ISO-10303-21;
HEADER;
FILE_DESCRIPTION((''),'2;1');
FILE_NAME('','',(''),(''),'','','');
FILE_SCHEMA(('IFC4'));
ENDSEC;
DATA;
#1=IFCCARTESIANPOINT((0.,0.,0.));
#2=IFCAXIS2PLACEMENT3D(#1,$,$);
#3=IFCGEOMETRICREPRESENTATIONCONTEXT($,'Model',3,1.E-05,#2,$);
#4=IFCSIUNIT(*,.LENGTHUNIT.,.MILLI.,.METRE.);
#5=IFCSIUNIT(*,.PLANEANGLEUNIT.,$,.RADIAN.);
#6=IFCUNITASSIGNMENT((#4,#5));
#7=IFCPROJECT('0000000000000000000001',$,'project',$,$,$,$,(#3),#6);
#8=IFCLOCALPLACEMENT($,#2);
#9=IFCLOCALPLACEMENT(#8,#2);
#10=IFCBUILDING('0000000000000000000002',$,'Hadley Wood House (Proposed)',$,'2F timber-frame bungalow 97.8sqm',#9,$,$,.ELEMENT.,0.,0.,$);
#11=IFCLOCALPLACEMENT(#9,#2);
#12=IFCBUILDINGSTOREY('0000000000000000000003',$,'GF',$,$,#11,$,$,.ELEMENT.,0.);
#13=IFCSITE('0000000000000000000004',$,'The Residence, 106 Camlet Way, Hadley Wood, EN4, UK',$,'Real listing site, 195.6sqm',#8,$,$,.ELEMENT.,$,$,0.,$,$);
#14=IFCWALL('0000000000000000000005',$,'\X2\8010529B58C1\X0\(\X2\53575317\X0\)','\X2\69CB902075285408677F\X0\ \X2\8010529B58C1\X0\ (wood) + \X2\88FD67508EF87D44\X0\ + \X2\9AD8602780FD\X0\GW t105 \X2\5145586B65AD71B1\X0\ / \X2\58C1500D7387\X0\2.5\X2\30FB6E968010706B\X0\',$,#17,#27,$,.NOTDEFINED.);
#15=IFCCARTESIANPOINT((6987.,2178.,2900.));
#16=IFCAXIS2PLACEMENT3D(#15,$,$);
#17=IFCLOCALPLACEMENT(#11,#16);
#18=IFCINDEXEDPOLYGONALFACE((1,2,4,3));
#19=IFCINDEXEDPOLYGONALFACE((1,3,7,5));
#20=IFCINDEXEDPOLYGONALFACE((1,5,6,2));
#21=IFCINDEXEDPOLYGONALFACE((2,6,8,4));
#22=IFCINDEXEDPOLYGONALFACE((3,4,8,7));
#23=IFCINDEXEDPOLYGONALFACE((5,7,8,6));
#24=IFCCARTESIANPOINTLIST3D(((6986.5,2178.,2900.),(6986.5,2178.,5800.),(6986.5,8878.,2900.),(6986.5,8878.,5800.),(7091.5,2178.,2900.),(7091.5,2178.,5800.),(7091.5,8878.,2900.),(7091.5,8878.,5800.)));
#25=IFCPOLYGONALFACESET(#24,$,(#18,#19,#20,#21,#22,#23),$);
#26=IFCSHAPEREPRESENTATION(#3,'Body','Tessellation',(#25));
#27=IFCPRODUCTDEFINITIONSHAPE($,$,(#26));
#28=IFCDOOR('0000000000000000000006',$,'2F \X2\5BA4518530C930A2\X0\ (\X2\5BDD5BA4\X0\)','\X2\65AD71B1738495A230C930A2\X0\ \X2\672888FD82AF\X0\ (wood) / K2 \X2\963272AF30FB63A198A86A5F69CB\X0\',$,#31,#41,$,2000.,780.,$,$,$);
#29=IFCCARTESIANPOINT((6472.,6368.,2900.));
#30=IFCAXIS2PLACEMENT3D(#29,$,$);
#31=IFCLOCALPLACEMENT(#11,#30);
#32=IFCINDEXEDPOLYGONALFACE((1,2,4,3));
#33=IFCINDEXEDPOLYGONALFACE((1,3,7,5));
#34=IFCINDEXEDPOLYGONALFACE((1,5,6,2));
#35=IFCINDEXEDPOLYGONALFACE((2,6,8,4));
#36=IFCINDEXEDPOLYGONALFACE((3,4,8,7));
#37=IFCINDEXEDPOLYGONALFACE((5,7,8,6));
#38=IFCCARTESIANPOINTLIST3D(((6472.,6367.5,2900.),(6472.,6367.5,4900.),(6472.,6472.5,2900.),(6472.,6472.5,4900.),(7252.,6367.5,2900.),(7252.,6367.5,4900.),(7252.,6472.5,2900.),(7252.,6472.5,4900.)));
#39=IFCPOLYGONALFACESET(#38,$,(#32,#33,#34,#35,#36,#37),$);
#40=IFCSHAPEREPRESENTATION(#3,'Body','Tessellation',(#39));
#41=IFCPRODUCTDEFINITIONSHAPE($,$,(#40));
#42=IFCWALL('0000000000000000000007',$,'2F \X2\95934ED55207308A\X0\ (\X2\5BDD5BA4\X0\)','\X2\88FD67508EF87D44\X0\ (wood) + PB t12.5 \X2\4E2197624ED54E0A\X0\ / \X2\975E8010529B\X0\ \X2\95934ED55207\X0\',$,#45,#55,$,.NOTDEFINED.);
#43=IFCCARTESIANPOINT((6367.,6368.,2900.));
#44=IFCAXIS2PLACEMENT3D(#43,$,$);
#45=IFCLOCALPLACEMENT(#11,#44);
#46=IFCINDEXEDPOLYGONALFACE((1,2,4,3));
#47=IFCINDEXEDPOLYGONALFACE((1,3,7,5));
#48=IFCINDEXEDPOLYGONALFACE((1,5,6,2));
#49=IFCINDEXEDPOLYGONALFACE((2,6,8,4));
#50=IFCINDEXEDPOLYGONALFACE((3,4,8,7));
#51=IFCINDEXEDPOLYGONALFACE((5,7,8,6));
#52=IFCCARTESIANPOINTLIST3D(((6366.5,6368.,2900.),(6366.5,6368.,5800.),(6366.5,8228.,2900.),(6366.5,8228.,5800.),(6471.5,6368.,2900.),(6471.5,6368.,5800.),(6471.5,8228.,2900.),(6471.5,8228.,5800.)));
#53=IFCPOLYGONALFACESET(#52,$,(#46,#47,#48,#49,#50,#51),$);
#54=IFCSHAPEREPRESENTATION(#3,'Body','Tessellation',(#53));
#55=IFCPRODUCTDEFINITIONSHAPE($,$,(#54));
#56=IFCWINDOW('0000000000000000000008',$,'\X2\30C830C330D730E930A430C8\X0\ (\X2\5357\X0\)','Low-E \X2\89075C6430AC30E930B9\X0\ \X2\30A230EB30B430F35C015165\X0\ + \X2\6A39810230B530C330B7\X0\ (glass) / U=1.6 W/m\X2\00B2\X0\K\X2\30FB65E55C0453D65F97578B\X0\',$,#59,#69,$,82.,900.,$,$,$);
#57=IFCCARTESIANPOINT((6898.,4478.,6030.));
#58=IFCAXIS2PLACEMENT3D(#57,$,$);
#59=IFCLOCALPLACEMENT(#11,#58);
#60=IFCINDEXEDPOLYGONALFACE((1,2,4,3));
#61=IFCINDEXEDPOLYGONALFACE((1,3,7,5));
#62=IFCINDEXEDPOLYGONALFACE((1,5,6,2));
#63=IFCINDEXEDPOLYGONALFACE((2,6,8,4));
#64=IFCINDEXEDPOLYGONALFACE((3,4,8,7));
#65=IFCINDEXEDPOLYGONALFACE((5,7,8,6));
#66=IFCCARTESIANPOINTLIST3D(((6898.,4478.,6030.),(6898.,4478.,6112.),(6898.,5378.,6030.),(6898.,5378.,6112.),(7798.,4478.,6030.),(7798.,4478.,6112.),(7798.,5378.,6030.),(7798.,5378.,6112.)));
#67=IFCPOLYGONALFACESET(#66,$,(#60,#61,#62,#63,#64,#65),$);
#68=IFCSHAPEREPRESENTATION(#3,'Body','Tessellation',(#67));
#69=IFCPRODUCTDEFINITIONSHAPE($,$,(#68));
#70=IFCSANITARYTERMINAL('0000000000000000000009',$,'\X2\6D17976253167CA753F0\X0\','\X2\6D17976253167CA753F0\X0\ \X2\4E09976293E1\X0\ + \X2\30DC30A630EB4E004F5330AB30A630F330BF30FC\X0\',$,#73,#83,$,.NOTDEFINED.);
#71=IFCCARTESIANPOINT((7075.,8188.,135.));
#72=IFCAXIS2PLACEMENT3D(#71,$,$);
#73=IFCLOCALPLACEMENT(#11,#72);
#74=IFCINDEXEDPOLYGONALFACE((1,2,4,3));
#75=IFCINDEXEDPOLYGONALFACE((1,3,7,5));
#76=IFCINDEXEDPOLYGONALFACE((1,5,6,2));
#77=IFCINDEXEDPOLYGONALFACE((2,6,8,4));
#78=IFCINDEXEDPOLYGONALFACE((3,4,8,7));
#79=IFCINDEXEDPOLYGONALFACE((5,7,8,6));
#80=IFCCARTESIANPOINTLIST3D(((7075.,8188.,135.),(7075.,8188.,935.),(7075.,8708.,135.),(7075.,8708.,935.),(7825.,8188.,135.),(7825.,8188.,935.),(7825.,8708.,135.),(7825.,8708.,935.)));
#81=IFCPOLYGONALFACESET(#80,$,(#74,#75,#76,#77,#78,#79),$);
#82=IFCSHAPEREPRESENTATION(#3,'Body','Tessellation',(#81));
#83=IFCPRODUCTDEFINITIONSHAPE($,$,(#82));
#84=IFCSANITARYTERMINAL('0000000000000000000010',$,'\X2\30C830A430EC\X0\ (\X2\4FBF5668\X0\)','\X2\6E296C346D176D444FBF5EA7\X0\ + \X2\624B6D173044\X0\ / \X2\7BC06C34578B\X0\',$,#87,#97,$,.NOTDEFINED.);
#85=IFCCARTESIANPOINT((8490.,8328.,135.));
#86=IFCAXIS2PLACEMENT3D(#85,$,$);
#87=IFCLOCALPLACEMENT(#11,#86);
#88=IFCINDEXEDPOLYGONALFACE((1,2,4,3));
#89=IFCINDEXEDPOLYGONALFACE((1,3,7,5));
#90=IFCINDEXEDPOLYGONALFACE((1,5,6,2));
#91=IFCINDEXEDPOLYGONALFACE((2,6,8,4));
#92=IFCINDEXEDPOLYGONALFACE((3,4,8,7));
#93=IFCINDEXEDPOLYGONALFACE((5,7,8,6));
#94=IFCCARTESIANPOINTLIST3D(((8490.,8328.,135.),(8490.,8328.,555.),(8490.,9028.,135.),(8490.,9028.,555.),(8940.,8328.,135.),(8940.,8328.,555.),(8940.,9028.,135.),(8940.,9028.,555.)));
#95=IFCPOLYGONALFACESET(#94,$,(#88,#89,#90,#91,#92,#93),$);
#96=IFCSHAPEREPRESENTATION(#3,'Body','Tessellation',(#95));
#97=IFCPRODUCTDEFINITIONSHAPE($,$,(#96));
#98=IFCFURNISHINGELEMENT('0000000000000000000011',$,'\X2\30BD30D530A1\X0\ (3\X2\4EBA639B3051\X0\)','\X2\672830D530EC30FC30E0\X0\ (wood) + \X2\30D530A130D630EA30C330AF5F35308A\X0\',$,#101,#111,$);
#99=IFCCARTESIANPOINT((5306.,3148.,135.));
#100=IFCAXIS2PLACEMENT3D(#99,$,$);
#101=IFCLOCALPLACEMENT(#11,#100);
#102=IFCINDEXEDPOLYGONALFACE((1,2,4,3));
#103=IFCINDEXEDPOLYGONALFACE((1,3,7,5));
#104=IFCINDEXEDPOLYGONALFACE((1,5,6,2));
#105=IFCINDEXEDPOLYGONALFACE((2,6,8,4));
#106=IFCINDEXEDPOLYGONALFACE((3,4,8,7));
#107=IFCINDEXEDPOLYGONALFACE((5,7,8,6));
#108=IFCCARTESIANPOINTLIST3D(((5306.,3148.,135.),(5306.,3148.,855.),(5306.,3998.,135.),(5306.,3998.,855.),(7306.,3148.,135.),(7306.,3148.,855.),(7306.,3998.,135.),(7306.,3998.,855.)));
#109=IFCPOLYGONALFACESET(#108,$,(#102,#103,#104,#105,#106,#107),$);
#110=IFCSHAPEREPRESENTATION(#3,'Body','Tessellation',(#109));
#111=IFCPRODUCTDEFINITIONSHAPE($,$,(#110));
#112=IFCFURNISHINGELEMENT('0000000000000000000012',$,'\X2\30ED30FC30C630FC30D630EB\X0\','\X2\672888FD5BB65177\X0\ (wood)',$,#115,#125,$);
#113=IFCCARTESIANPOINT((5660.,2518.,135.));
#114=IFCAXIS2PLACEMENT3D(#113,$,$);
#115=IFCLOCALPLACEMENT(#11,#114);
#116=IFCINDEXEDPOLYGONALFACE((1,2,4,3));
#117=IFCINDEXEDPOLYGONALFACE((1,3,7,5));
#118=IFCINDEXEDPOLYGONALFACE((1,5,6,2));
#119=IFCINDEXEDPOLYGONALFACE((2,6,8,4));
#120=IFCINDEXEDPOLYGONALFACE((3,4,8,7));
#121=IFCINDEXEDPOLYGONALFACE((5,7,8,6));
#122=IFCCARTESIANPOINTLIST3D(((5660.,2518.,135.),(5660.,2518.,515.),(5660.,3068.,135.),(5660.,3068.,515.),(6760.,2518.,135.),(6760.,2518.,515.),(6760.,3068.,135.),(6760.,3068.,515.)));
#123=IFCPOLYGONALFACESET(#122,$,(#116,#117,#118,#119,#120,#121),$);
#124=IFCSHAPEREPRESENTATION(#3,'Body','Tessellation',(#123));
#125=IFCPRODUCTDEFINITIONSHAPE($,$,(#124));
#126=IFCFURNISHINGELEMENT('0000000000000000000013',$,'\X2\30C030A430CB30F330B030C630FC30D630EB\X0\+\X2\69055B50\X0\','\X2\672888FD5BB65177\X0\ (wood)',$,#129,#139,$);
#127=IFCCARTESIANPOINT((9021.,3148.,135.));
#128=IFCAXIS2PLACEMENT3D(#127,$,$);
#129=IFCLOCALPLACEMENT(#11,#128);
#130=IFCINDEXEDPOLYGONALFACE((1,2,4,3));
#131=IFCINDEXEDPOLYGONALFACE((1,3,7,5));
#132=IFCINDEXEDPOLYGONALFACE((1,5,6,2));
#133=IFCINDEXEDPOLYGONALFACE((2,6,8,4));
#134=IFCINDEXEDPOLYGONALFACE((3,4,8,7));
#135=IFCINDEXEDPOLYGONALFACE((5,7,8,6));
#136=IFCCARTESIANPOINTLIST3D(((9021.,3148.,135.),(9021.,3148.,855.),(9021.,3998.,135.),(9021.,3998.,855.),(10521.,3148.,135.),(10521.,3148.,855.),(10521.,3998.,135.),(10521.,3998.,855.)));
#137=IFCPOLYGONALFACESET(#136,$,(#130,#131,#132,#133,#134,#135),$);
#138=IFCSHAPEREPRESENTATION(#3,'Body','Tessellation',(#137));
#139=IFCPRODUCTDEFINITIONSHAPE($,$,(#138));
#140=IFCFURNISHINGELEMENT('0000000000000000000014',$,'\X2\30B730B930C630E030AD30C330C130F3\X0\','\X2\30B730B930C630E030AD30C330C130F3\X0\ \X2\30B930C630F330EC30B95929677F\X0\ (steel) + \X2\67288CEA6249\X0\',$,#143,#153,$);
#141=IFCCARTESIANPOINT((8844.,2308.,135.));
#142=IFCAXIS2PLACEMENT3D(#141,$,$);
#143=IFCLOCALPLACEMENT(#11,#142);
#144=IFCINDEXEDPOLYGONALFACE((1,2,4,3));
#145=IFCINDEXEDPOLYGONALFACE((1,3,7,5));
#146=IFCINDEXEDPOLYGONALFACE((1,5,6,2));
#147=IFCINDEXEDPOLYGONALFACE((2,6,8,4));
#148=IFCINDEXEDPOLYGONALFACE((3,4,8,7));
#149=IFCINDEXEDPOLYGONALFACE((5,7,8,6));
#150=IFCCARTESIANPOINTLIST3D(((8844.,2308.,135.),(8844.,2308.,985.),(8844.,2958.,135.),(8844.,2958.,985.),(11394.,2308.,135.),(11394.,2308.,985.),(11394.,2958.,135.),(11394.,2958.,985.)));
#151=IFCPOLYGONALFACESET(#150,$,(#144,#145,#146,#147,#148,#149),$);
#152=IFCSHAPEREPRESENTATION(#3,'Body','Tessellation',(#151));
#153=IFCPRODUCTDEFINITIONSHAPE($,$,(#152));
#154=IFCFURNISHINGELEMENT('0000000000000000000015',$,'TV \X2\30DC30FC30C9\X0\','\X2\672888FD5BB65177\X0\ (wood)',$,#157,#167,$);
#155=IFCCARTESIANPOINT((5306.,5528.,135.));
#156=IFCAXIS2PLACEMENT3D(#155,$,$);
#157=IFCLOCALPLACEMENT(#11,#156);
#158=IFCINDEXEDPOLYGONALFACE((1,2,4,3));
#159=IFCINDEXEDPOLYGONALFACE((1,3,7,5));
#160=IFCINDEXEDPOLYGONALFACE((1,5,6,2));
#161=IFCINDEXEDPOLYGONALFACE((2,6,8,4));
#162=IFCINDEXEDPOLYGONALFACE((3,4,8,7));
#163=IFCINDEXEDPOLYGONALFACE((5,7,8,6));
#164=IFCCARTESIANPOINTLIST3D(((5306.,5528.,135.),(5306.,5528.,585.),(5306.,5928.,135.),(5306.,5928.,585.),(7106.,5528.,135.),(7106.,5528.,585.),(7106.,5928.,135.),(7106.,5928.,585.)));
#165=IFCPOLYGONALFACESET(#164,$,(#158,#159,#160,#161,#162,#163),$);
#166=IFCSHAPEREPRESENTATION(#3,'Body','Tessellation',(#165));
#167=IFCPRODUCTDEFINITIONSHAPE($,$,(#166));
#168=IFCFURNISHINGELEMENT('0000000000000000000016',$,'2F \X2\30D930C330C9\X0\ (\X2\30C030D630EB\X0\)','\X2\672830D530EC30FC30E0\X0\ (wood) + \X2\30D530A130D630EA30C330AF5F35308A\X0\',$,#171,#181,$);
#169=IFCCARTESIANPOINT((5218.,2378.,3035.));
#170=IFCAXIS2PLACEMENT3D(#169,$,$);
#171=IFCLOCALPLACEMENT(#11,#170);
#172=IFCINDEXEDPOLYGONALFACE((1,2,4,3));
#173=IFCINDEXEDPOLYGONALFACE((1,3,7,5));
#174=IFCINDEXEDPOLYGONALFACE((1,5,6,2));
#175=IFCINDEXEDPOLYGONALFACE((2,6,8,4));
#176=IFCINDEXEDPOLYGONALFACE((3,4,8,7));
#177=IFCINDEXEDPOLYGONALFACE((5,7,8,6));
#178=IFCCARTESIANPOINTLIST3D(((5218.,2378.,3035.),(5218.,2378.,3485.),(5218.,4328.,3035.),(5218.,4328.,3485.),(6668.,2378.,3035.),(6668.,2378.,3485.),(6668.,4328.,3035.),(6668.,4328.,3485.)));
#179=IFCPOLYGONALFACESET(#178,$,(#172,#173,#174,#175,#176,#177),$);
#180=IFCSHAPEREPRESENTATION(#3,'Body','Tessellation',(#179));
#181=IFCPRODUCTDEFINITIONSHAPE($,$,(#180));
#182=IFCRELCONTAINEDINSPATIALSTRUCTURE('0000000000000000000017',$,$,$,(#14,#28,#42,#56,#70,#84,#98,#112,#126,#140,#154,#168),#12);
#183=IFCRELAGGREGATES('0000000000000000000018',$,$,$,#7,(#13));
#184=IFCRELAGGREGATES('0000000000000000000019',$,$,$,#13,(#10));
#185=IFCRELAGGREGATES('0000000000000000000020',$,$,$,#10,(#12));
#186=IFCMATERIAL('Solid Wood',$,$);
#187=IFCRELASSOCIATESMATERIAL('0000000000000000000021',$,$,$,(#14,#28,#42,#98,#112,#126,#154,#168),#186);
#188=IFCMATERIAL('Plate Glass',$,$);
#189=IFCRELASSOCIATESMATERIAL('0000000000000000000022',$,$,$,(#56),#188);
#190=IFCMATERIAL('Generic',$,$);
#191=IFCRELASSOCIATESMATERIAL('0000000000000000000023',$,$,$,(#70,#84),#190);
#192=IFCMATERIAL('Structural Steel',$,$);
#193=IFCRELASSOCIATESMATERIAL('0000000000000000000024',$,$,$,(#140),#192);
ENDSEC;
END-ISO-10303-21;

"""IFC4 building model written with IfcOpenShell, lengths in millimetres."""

from ifc_helpers import new_model, si_unit, frame, frame_2d, origin, place, context, project, spatial, rectangle, extrude, material, element, fill, save


model = new_model("IFC4")

# Units and contexts
model_context = context("Model", 3, precision=1e-05, world=origin())
ifc_project = project(units=[si_unit("LENGTHUNIT", "METRE", prefix="MILLI"), si_unit("PLANEANGLEUNIT", "RADIAN")], contexts=[model_context])

# Site, building, storey
site_placement = place(None, origin())
site = spatial("IfcSite", under=ifc_project, at=site_placement, Name="The Residence, 106 Camlet Way, Hadley Wood, EN4, UK", ObjectType="Real listing site, 195.6sqm", CompositionType="ELEMENT", RefElevation=0.0)
building_placement = place(site_placement, origin())
building = spatial("IfcBuilding", under=site, at=building_placement, Name="Hadley Wood House (Proposed)", ObjectType="2F timber-frame bungalow 97.8sqm", CompositionType="ELEMENT", ElevationOfRefHeight=0.0, ElevationOfTerrain=0.0)
storey_placement = place(building_placement, origin())
storey = spatial("IfcBuildingStorey", under=building, at=storey_placement, Name="GF", CompositionType="ELEMENT", Elevation=0.0)

# Shared definitions
ifc_material_1 = material(Name="Solid Wood")

# Wall, opening, door
wall_1_placement = place(storey_placement, frame((6987.0, 2178.0, 2900.0)))
wall_1 = element("IfcWall", 1, at=wall_1_placement, inside=storey, material=ifc_material_1, Name="耐力壁(南北)", Description="構造用合板 耐力壁 (wood) + 製材軸組 + 高性能GW t105 充填断熱 / 壁倍率2.5・準耐火", PredefinedType="NOTDEFINED", context=model_context, shape_type="SweptSolid", body=[
    extrude(rectangle(XDim=105.0, YDim=6700.0, at=frame_2d((52.0, 3350.0))), frame((6987.0, 2178.0, 2900.0)), (0.0, 0.0, 1.0), 2900.0),
])
opening_1_placement = place(storey_placement, frame((6472.0, 6368.0, 2900.0)))
opening_1 = element("IfcOpeningElement", 2, at=opening_1_placement, cuts=wall_1, PredefinedType="NOTDEFINED", context=model_context, shape_type="SweptSolid", body=[
    extrude(rectangle(XDim=780.0, YDim=105.0, at=frame_2d((390.0, 52.0))), frame((6472.0, 6368.0, 2900.0)), (0.0, 0.0, 1.0), 2000.0),
])
door_1_placement = place(storey_placement, frame((6472.0, 6368.0, 2900.0)))
door_1 = element("IfcDoor", 3, at=door_1_placement, inside=storey, material=ifc_material_1, Name="2F 室内ドア (寝室)", Description="断熱玄関ドア 木製芯 (wood) / K2 防犯・採風機構", OverallHeight=2000.0, OverallWidth=780.0, context=model_context, shape_type="SweptSolid", body=[
    extrude(rectangle(XDim=780.0, YDim=105.0, at=frame_2d((390.0, 52.0))), frame((6472.0, 6368.0, 2900.0)), (0.0, 0.0, 1.0), 2000.0),
])
fill(opening_1, door_1)

# Wall
wall_2_placement = place(storey_placement, frame((6367.0, 6368.0, 2900.0)))
element("IfcWall", 4, at=wall_2_placement, inside=storey, material=ifc_material_1, Name="2F 間仕切り (寝室)", Description="製材軸組 (wood) + PB t12.5 両面仕上 / 非耐力 間仕切", PredefinedType="NOTDEFINED", context=model_context, shape_type="SweptSolid", body=[
    extrude(rectangle(XDim=105.0, YDim=1860.0, at=frame_2d((52.0, 930.0))), frame((6367.0, 6368.0, 2900.0)), (0.0, 0.0, 1.0), 2900.0),
])

# Window
ifc_material_2 = material(Name="Plate Glass")
window_placement = place(storey_placement, frame((6898.0, 4478.0, 6030.0)))
element("IfcWindow", 5, at=window_placement, inside=storey, material=ifc_material_2, Name="トップライト (南)", Description="Low-E 複層ガラス アルゴン封入 + 樹脂サッシ (glass) / U=1.6 W/m²K・日射取得型", OverallHeight=82.0, OverallWidth=900.0, context=model_context, shape_type="SweptSolid", body=[
    extrude(rectangle(XDim=900.0, YDim=900.0, at=frame_2d((450.0, 450.0))), frame((6898.0, 4478.0, 6030.0)), (0.0, 0.0, 1.0), 82.0),
])

# Sanitary terminals
ifc_material_3 = material(Name="Generic")
sanitary_terminal_1_placement = place(storey_placement, frame((7075.0, 8188.0, 135.0)))
element("IfcSanitaryTerminal", 6, at=sanitary_terminal_1_placement, inside=storey, material=ifc_material_3, Name="洗面化粧台", Description="洗面化粧台 三面鏡 + ボウル一体カウンター", PredefinedType="NOTDEFINED", context=model_context, shape_type="SweptSolid", body=[
    extrude(rectangle(XDim=750.0, YDim=520.0, at=frame_2d((375.0, 260.0))), frame((7075.0, 8188.0, 135.0)), (0.0, 0.0, 1.0), 800.0),
])
sanitary_terminal_2_placement = place(storey_placement, frame((8490.0, 8328.0, 135.0)))
element("IfcSanitaryTerminal", 7, at=sanitary_terminal_2_placement, inside=storey, material=ifc_material_3, Name="トイレ (便器)", Description="温水洗浄便座 + 手洗い / 節水型", PredefinedType="NOTDEFINED", context=model_context, shape_type="SweptSolid", body=[
    extrude(rectangle(XDim=450.0, YDim=700.0, at=frame_2d((225.0, 350.0))), frame((8490.0, 8328.0, 135.0)), (0.0, 0.0, 1.0), 420.0),
])

# Furnishing elements
furnishing_1_placement = place(storey_placement, frame((5306.0, 3148.0, 135.0)))
element("IfcFurnishingElement", 8, at=furnishing_1_placement, inside=storey, material=ifc_material_1, Name="ソファ (3人掛け)", Description="木フレーム (wood) + ファブリック張り", context=model_context, shape_type="SweptSolid", body=[
    extrude(rectangle(XDim=2000.0, YDim=850.0, at=frame_2d((1000.0, 425.0))), frame((5306.0, 3148.0, 135.0)), (0.0, 0.0, 1.0), 720.0),
])
furnishing_2_placement = place(storey_placement, frame((5660.0, 2518.0, 135.0)))
element("IfcFurnishingElement", 9, at=furnishing_2_placement, inside=storey, material=ifc_material_1, Name="ローテーブル", Description="木製家具 (wood)", context=model_context, shape_type="SweptSolid", body=[
    extrude(rectangle(XDim=1100.0, YDim=550.0, at=frame_2d((550.0, 275.0))), frame((5660.0, 2518.0, 135.0)), (0.0, 0.0, 1.0), 380.0),
])
furnishing_3_placement = place(storey_placement, frame((9021.0, 3148.0, 135.0)))
element("IfcFurnishingElement", 10, at=furnishing_3_placement, inside=storey, material=ifc_material_1, Name="ダイニングテーブル+椅子", Description="木製家具 (wood)", context=model_context, shape_type="SweptSolid", body=[
    extrude(rectangle(XDim=1500.0, YDim=850.0, at=frame_2d((750.0, 425.0))), frame((9021.0, 3148.0, 135.0)), (0.0, 0.0, 1.0), 720.0),
])
ifc_material_4 = material(Name="Structural Steel")
furnishing_4_placement = place(storey_placement, frame((8844.0, 2308.0, 135.0)))
element("IfcFurnishingElement", 11, at=furnishing_4_placement, inside=storey, material=ifc_material_4, Name="システムキッチン", Description="システムキッチン ステンレス天板 (steel) + 木質扉", context=model_context, shape_type="SweptSolid", body=[
    extrude(rectangle(XDim=2550.0, YDim=650.0, at=frame_2d((1275.0, 325.0))), frame((8844.0, 2308.0, 135.0)), (0.0, 0.0, 1.0), 850.0),
])
furnishing_5_placement = place(storey_placement, frame((5306.0, 5528.0, 135.0)))
element("IfcFurnishingElement", 12, at=furnishing_5_placement, inside=storey, material=ifc_material_1, Name="TV ボード", Description="木製家具 (wood)", context=model_context, shape_type="SweptSolid", body=[
    extrude(rectangle(XDim=1800.0, YDim=400.0, at=frame_2d((900.0, 200.0))), frame((5306.0, 5528.0, 135.0)), (0.0, 0.0, 1.0), 450.0),
])
furnishing_6_placement = place(storey_placement, frame((5218.0, 2378.0, 3035.0)))
element("IfcFurnishingElement", 13, at=furnishing_6_placement, inside=storey, material=ifc_material_1, Name="2F ベッド (ダブル)", Description="木フレーム (wood) + ファブリック張り", context=model_context, shape_type="SweptSolid", body=[
    extrude(rectangle(XDim=1450.0, YDim=1950.0, at=frame_2d((725.0, 975.0))), frame((5218.0, 2378.0, 3035.0)), (0.0, 0.0, 1.0), 450.0),
])

save(model, "model.ifc")
